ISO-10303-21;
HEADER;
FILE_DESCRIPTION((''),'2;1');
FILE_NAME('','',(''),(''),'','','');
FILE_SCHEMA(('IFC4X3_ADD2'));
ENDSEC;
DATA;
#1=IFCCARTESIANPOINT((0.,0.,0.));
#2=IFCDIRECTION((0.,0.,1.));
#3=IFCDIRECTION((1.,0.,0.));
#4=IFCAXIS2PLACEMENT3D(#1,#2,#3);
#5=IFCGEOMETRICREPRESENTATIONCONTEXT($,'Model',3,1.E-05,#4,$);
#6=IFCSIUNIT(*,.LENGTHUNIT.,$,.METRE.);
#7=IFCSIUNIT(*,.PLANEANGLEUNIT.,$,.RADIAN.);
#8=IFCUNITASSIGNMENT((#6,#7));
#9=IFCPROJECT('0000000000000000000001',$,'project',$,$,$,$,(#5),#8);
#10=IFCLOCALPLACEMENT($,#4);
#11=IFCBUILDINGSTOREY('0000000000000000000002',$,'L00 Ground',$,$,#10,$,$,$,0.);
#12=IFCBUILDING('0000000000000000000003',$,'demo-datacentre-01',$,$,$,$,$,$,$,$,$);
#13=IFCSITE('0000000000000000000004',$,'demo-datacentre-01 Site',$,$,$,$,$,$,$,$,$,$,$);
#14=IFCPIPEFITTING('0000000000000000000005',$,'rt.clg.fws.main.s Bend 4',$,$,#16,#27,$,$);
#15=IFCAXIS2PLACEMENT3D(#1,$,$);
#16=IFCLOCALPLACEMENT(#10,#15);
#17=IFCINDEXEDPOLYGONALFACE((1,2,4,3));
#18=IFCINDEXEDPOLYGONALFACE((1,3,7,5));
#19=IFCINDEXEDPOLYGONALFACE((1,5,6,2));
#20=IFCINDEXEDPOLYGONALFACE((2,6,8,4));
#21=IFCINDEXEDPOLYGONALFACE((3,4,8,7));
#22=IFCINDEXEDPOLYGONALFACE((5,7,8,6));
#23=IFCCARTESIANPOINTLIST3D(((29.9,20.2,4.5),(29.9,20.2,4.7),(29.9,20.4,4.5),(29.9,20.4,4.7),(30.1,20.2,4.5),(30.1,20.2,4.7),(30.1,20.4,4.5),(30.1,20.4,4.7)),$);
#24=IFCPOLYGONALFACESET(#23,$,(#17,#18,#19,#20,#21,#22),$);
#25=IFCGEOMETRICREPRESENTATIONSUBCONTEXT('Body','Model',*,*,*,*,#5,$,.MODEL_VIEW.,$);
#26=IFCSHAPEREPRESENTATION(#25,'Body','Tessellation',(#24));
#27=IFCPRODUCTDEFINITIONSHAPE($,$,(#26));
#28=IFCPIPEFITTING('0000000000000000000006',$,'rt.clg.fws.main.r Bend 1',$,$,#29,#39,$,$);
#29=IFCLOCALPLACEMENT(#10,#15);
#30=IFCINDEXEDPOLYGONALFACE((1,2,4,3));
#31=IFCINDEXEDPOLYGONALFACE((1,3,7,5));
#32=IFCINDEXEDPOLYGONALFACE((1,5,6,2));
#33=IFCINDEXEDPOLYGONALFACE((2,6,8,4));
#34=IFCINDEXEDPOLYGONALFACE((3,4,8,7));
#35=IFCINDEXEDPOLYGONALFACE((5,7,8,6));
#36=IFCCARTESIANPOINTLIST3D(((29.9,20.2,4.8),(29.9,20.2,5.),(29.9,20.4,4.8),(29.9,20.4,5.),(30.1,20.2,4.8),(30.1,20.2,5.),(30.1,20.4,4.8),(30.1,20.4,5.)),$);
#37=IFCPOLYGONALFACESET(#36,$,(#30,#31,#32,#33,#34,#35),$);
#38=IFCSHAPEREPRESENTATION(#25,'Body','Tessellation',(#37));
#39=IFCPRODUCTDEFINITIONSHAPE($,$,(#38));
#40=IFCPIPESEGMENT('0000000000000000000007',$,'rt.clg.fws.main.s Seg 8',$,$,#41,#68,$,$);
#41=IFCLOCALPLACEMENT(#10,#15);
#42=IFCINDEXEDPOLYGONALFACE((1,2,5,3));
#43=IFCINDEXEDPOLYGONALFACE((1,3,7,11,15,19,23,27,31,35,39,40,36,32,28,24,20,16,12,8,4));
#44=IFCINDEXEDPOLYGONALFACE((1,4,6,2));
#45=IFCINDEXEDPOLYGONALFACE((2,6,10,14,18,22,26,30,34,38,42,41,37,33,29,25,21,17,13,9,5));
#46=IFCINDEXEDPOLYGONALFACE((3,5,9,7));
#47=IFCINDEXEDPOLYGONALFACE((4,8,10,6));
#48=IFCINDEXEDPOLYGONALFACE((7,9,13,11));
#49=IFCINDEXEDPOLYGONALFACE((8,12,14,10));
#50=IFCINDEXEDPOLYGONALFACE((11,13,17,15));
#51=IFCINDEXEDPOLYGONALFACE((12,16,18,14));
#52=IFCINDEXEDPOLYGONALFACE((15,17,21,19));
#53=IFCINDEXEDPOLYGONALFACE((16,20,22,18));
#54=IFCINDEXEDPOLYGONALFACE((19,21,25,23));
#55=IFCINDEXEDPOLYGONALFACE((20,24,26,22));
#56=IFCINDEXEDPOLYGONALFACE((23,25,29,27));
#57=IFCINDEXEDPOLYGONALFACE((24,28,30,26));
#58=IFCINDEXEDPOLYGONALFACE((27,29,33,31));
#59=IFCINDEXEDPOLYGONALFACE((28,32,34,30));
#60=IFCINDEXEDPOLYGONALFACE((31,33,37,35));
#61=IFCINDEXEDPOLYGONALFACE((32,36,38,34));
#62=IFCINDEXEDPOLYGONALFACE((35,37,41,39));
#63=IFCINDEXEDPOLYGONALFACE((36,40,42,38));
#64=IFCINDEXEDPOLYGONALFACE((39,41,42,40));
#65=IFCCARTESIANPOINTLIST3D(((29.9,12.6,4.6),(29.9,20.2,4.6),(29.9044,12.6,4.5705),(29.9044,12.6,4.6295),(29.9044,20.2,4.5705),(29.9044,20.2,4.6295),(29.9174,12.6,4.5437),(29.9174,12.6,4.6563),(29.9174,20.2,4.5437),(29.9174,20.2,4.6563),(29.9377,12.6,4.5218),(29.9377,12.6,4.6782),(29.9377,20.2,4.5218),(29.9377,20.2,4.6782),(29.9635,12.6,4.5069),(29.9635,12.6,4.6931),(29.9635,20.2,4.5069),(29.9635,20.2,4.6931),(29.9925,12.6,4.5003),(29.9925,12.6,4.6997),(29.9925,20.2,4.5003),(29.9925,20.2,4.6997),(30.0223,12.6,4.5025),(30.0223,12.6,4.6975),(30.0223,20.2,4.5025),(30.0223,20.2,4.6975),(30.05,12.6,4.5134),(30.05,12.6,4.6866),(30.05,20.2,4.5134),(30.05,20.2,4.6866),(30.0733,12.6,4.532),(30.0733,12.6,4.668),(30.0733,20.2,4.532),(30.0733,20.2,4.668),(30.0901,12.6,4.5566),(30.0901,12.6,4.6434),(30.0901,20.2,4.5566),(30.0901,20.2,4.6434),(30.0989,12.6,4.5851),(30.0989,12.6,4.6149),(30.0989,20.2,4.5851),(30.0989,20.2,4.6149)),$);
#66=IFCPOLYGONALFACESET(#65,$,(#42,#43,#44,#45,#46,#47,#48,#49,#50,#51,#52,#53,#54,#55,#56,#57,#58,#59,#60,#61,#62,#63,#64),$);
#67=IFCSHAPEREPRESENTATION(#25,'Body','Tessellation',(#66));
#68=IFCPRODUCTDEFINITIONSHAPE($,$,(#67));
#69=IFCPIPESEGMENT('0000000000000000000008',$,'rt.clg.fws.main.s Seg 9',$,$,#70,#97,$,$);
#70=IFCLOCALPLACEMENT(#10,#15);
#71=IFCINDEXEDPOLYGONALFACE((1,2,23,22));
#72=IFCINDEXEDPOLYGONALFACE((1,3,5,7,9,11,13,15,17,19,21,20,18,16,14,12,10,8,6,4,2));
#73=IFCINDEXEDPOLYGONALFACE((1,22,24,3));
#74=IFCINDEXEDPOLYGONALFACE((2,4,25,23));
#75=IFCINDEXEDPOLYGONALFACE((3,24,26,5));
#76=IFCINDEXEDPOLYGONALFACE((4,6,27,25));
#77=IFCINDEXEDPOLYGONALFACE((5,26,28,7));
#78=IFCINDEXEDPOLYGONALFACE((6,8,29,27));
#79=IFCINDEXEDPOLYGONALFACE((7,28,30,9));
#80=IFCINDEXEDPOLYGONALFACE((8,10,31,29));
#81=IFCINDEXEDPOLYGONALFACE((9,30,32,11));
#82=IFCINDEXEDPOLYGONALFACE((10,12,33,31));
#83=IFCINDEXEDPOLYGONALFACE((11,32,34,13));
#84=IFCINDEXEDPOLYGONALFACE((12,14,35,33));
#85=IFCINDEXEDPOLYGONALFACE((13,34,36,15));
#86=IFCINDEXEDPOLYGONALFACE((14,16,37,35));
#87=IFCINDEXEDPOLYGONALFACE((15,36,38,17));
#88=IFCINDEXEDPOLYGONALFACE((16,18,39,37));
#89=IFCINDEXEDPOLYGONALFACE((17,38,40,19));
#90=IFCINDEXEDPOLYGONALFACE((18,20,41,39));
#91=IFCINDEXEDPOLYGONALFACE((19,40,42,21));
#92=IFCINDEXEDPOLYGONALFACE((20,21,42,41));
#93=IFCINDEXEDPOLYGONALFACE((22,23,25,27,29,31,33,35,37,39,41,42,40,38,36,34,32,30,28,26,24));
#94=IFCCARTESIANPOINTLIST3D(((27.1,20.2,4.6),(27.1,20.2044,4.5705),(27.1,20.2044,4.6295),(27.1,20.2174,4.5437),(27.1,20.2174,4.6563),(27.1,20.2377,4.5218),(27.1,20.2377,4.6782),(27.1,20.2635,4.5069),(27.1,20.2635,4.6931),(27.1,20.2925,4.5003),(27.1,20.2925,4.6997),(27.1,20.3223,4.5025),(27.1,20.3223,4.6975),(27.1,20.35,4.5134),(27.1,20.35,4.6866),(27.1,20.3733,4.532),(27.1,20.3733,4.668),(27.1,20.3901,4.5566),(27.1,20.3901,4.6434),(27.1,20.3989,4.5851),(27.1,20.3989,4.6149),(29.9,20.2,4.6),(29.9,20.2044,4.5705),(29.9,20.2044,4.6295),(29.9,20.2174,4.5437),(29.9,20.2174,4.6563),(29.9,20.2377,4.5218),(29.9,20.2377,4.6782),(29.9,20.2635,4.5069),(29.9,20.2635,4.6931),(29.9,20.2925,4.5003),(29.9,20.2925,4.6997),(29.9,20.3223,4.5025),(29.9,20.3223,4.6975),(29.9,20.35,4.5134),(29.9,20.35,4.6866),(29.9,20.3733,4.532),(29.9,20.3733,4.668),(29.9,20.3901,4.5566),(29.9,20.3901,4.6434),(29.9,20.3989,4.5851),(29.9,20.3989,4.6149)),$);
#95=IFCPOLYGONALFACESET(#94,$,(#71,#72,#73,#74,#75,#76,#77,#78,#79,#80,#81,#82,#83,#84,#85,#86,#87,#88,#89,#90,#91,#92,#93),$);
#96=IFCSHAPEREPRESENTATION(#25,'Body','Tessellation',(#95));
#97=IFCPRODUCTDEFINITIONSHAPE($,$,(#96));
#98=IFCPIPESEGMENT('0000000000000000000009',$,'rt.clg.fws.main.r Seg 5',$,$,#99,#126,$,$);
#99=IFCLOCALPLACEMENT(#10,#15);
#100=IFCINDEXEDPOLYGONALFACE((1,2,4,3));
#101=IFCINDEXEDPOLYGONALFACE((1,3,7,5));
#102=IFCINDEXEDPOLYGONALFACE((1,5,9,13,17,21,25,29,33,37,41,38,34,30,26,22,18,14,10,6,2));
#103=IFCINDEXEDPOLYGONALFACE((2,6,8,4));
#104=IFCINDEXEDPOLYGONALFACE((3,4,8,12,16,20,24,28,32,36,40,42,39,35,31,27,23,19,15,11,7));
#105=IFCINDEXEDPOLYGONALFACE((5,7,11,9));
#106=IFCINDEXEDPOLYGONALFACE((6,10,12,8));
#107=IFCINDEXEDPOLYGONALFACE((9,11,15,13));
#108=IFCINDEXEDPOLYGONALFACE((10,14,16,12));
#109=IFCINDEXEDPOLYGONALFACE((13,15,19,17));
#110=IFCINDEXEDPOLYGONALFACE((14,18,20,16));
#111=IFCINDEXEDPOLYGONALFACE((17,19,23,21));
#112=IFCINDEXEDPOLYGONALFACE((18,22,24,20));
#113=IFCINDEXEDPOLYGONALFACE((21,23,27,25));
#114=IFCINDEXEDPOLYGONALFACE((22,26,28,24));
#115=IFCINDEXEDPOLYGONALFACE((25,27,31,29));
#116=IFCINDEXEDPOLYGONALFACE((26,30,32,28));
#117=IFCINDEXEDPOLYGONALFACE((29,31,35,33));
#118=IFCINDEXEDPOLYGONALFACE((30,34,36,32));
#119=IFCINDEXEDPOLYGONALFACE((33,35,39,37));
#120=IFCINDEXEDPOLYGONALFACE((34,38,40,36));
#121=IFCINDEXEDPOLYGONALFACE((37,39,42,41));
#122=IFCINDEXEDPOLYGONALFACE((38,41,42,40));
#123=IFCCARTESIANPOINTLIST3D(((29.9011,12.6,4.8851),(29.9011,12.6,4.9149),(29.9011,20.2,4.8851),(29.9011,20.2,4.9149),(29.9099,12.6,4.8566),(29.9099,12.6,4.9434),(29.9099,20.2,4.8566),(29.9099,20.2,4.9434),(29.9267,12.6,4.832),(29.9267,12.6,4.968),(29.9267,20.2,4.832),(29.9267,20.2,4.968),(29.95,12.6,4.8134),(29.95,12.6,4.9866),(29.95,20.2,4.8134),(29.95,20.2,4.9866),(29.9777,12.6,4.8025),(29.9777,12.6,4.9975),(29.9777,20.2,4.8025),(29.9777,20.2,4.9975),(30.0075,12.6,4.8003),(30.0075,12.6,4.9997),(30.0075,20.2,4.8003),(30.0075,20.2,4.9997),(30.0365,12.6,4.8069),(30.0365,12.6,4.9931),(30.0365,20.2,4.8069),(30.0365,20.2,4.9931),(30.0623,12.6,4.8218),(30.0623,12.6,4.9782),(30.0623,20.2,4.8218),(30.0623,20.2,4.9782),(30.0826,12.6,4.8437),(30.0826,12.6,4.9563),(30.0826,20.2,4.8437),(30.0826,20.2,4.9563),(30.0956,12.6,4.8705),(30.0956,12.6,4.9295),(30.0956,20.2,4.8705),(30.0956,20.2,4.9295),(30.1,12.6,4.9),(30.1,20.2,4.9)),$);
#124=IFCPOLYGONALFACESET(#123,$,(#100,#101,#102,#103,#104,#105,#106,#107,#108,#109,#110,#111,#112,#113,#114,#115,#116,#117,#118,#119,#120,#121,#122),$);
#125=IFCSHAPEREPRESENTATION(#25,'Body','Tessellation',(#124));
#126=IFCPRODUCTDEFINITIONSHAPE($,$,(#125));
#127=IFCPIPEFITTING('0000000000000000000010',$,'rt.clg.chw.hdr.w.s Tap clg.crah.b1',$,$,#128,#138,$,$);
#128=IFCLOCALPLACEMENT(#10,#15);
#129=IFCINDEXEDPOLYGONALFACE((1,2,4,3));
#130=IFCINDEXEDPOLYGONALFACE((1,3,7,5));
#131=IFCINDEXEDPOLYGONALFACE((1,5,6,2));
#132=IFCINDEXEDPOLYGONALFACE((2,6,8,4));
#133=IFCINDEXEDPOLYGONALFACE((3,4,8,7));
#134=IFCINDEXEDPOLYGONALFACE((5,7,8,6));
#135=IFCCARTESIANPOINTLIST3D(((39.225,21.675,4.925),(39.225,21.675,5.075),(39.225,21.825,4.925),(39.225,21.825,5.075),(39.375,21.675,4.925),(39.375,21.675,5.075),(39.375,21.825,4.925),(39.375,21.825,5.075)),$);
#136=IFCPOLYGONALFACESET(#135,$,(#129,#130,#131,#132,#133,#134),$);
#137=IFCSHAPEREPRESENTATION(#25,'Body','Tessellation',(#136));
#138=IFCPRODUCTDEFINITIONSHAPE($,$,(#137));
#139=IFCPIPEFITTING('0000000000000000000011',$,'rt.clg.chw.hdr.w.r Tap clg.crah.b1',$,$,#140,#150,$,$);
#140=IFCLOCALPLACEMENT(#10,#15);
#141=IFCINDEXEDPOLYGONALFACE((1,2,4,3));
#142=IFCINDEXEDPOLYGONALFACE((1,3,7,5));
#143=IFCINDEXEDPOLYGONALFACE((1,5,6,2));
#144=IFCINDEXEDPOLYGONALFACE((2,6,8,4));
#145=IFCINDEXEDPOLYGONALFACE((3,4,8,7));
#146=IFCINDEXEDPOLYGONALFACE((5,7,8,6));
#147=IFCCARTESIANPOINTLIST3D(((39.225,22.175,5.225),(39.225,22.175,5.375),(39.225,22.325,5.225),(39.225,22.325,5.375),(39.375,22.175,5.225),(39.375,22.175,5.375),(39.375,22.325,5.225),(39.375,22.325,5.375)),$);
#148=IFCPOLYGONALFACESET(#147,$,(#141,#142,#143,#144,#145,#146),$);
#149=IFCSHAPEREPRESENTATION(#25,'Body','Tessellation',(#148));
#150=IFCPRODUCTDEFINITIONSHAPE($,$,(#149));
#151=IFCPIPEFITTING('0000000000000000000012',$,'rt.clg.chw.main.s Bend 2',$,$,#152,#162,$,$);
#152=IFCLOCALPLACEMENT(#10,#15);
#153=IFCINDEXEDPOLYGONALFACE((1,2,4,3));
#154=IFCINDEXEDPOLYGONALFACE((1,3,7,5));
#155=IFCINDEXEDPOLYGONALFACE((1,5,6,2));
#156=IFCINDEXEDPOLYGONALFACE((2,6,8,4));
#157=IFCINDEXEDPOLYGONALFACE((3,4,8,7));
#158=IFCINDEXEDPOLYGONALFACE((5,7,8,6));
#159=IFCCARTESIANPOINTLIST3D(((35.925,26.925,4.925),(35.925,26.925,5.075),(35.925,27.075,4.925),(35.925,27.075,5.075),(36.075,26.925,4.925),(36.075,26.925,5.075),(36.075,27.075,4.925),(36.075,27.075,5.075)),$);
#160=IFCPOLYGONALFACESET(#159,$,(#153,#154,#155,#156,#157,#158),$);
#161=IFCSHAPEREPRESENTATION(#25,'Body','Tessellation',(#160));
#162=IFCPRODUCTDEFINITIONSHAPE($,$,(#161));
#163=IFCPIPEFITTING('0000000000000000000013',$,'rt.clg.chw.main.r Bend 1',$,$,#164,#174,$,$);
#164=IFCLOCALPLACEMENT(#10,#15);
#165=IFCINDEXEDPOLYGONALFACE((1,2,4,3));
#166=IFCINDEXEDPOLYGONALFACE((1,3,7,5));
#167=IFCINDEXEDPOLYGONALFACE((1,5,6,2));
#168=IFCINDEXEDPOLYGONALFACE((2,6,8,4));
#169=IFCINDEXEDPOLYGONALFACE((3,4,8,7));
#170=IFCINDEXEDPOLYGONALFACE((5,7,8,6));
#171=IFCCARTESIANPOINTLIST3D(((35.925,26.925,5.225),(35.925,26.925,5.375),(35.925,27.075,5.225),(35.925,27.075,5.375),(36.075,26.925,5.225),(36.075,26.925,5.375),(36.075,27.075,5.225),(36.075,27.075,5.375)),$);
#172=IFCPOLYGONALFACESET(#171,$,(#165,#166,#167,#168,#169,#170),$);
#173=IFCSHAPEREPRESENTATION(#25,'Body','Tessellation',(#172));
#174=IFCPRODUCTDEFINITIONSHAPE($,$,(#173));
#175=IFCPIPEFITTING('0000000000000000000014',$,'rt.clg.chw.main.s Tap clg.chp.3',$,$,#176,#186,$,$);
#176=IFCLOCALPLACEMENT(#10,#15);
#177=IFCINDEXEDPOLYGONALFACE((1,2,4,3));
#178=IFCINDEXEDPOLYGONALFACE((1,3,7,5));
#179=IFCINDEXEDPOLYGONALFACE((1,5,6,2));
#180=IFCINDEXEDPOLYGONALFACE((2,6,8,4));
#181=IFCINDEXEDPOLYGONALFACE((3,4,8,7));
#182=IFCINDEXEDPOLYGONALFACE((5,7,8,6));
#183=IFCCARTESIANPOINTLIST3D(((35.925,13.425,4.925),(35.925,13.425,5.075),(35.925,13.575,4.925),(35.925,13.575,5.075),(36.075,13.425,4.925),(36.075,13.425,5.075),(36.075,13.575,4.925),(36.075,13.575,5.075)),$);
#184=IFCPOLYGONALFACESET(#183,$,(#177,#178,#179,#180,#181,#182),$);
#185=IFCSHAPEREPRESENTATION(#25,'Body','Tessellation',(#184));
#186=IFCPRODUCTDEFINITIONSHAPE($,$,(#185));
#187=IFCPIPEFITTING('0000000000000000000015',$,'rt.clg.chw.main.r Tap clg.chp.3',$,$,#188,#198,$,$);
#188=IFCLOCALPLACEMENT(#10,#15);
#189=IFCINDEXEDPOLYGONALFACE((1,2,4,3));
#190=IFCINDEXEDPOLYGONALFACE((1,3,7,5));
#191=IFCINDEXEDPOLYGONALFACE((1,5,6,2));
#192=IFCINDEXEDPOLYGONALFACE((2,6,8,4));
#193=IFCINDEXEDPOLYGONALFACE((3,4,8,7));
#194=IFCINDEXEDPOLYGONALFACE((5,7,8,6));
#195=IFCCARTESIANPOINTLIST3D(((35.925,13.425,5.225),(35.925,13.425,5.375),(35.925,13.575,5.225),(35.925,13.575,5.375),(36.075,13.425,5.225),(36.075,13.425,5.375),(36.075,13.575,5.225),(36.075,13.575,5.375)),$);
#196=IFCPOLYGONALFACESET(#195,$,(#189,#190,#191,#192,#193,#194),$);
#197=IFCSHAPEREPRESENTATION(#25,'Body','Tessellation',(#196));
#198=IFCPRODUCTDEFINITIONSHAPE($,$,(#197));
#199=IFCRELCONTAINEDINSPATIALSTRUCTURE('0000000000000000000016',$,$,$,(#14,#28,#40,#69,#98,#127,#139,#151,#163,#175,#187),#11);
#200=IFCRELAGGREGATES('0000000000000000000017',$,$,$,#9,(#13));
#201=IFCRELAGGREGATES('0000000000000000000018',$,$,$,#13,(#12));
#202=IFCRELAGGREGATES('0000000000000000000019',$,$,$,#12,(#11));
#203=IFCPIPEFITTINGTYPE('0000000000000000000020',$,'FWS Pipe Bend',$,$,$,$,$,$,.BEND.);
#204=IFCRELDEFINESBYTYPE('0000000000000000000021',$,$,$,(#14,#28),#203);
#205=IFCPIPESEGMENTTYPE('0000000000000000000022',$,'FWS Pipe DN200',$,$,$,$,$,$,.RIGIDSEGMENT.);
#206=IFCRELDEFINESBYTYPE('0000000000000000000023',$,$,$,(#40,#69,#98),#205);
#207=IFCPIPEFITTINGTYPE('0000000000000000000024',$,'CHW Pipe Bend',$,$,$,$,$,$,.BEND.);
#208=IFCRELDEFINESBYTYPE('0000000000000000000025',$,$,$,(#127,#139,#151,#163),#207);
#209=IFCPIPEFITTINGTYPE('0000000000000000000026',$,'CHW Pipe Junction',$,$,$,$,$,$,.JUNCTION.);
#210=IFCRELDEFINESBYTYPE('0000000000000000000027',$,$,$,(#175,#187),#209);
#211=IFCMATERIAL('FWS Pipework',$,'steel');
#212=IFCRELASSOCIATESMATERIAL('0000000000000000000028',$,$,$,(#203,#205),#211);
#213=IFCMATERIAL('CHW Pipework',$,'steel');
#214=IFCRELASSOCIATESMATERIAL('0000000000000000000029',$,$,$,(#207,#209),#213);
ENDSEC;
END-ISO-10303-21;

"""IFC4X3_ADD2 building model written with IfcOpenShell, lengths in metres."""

from ifc_helpers import new_model, si_unit, frame, origin_with_axes, place, context, subcontext, project, spatial, rectangle, circle, extrude, material, type_object, element, save


model = new_model("IFC4X3_ADD2")

# Units and contexts
model_context = context("Model", 3, precision=1e-05, world=origin_with_axes())
body_context = subcontext(model_context, "Body", "Model", "MODEL_VIEW")
ifc_project = project(units=[si_unit("LENGTHUNIT", "METRE"), si_unit("PLANEANGLEUNIT", "RADIAN")], contexts=[model_context])

# Site, building, storey
site = spatial("IfcSite", under=ifc_project, Name="demo-datacentre-01 Site")
building = spatial("IfcBuilding", under=site, Name="demo-datacentre-01")
storey_placement = place(None, origin_with_axes())
storey = spatial("IfcBuildingStorey", under=building, at=storey_placement, Name="L00 Ground", Elevation=0.0)

# Pipe fittings
ifc_material_1 = material(Name="FWS Pipework", Category="steel")
pipe_fitting_type_1 = type_object("IfcPipeFittingType", Name="FWS Pipe Bend", PredefinedType="BEND", material=ifc_material_1)
for number, where, z_axis, x_axis, name in (
    (1, (30.0, 20.3, 4.5), (0.0, 0.0, 1.0), (1.0, 0.0, 0.0), "rt.clg.fws.main.s Bend 4"),
    (2, (30.0, 20.3, 4.8), (0.0, 0.0, 1.0), (1.0, 0.0, 0.0), "rt.clg.fws.main.r Bend 1"),
):
    element("IfcPipeFitting", number, at=place(storey_placement, frame(where, z_axis=z_axis, x_axis=x_axis)), inside=storey, type_object=pipe_fitting_type_1, Name=name, context=body_context, shape_type="SweptSolid", body=[
        extrude(rectangle(XDim=0.2, YDim=0.2), origin_with_axes(), (0.0, 0.0, 1.0), 0.2),
    ])

# Pipe segments
pipe_segment_type_1 = type_object("IfcPipeSegmentType", Name="FWS Pipe DN200", PredefinedType="RIGIDSEGMENT", material=ifc_material_1)
pipe_segment_1_placement = place(storey_placement, frame((30.0, 12.6, 4.6), z_axis=(0.0, 1.0, 0.0), x_axis=(-1.0, 0.0, 0.0)))
element("IfcPipeSegment", 3, at=pipe_segment_1_placement, inside=storey, type_object=pipe_segment_type_1, Name="rt.clg.fws.main.s Seg 8", context=body_context, shape_type="SweptSolid", body=[
    extrude(circle(Radius=0.1), origin_with_axes(), (0.0, 0.0, 1.0), 7.6),
])
pipe_segment_2_placement = place(storey_placement, frame((29.9, 20.3, 4.6), z_axis=(-1.0, 0.0, 0.0), x_axis=(0.0, -1.0, 0.0)))
element("IfcPipeSegment", 4, at=pipe_segment_2_placement, inside=storey, type_object=pipe_segment_type_1, Name="rt.clg.fws.main.s Seg 9", context=body_context, shape_type="SweptSolid", body=[
    extrude(circle(Radius=0.1), origin_with_axes(), (0.0, 0.0, 1.0), 2.8),
])
pipe_segment_3_placement = place(storey_placement, frame((30.0, 20.2, 4.9), z_axis=(0.0, -1.0, 0.0), x_axis=(1.0, 0.0, 0.0)))
element("IfcPipeSegment", 5, at=pipe_segment_3_placement, inside=storey, type_object=pipe_segment_type_1, Name="rt.clg.fws.main.r Seg 5", context=body_context, shape_type="SweptSolid", body=[
    extrude(circle(Radius=0.1), origin_with_axes(), (0.0, 0.0, 1.0), 7.6),
])

# Pipe fittings
ifc_material_2 = material(Name="CHW Pipework", Category="steel")
pipe_fitting_type_2 = type_object("IfcPipeFittingType", Name="CHW Pipe Bend", PredefinedType="BEND", material=ifc_material_2)
for number, where, z_axis, x_axis, name in (
    (6, (39.3, 21.75, 4.925), (0.0, 0.0, 1.0), (1.0, 0.0, 0.0), "rt.clg.chw.hdr.w.s Tap clg.crah.b1"),
    (7, (39.3, 22.25, 5.225), (0.0, 0.0, 1.0), (1.0, 0.0, 0.0), "rt.clg.chw.hdr.w.r Tap clg.crah.b1"),
    (8, (36.0, 27.0, 4.925), (0.0, 0.0, 1.0), (1.0, 0.0, 0.0), "rt.clg.chw.main.s Bend 2"),
    (9, (36.0, 27.0, 5.225), (0.0, 0.0, 1.0), (1.0, 0.0, 0.0), "rt.clg.chw.main.r Bend 1"),
):
    element("IfcPipeFitting", number, at=place(storey_placement, frame(where, z_axis=z_axis, x_axis=x_axis)), inside=storey, type_object=pipe_fitting_type_2, Name=name, context=body_context, shape_type="SweptSolid", body=[
        extrude(rectangle(XDim=0.15, YDim=0.15), origin_with_axes(), (0.0, 0.0, 1.0), 0.15),
    ])
pipe_fitting_type_3 = type_object("IfcPipeFittingType", Name="CHW Pipe Junction", PredefinedType="JUNCTION", material=ifc_material_2)
for number, where, z_axis, x_axis, name in (
    (10, (36.0, 13.5, 4.925), (0.0, 0.0, 1.0), (1.0, 0.0, 0.0), "rt.clg.chw.main.s Tap clg.chp.3"),
    (11, (36.0, 13.5, 5.225), (0.0, 0.0, 1.0), (1.0, 0.0, 0.0), "rt.clg.chw.main.r Tap clg.chp.3"),
):
    element("IfcPipeFitting", number, at=place(storey_placement, frame(where, z_axis=z_axis, x_axis=x_axis)), inside=storey, type_object=pipe_fitting_type_3, Name=name, context=body_context, shape_type="SweptSolid", body=[
        extrude(rectangle(XDim=0.15, YDim=0.15), origin_with_axes(), (0.0, 0.0, 1.0), 0.15),
    ])

save(model, "model.ifc")
